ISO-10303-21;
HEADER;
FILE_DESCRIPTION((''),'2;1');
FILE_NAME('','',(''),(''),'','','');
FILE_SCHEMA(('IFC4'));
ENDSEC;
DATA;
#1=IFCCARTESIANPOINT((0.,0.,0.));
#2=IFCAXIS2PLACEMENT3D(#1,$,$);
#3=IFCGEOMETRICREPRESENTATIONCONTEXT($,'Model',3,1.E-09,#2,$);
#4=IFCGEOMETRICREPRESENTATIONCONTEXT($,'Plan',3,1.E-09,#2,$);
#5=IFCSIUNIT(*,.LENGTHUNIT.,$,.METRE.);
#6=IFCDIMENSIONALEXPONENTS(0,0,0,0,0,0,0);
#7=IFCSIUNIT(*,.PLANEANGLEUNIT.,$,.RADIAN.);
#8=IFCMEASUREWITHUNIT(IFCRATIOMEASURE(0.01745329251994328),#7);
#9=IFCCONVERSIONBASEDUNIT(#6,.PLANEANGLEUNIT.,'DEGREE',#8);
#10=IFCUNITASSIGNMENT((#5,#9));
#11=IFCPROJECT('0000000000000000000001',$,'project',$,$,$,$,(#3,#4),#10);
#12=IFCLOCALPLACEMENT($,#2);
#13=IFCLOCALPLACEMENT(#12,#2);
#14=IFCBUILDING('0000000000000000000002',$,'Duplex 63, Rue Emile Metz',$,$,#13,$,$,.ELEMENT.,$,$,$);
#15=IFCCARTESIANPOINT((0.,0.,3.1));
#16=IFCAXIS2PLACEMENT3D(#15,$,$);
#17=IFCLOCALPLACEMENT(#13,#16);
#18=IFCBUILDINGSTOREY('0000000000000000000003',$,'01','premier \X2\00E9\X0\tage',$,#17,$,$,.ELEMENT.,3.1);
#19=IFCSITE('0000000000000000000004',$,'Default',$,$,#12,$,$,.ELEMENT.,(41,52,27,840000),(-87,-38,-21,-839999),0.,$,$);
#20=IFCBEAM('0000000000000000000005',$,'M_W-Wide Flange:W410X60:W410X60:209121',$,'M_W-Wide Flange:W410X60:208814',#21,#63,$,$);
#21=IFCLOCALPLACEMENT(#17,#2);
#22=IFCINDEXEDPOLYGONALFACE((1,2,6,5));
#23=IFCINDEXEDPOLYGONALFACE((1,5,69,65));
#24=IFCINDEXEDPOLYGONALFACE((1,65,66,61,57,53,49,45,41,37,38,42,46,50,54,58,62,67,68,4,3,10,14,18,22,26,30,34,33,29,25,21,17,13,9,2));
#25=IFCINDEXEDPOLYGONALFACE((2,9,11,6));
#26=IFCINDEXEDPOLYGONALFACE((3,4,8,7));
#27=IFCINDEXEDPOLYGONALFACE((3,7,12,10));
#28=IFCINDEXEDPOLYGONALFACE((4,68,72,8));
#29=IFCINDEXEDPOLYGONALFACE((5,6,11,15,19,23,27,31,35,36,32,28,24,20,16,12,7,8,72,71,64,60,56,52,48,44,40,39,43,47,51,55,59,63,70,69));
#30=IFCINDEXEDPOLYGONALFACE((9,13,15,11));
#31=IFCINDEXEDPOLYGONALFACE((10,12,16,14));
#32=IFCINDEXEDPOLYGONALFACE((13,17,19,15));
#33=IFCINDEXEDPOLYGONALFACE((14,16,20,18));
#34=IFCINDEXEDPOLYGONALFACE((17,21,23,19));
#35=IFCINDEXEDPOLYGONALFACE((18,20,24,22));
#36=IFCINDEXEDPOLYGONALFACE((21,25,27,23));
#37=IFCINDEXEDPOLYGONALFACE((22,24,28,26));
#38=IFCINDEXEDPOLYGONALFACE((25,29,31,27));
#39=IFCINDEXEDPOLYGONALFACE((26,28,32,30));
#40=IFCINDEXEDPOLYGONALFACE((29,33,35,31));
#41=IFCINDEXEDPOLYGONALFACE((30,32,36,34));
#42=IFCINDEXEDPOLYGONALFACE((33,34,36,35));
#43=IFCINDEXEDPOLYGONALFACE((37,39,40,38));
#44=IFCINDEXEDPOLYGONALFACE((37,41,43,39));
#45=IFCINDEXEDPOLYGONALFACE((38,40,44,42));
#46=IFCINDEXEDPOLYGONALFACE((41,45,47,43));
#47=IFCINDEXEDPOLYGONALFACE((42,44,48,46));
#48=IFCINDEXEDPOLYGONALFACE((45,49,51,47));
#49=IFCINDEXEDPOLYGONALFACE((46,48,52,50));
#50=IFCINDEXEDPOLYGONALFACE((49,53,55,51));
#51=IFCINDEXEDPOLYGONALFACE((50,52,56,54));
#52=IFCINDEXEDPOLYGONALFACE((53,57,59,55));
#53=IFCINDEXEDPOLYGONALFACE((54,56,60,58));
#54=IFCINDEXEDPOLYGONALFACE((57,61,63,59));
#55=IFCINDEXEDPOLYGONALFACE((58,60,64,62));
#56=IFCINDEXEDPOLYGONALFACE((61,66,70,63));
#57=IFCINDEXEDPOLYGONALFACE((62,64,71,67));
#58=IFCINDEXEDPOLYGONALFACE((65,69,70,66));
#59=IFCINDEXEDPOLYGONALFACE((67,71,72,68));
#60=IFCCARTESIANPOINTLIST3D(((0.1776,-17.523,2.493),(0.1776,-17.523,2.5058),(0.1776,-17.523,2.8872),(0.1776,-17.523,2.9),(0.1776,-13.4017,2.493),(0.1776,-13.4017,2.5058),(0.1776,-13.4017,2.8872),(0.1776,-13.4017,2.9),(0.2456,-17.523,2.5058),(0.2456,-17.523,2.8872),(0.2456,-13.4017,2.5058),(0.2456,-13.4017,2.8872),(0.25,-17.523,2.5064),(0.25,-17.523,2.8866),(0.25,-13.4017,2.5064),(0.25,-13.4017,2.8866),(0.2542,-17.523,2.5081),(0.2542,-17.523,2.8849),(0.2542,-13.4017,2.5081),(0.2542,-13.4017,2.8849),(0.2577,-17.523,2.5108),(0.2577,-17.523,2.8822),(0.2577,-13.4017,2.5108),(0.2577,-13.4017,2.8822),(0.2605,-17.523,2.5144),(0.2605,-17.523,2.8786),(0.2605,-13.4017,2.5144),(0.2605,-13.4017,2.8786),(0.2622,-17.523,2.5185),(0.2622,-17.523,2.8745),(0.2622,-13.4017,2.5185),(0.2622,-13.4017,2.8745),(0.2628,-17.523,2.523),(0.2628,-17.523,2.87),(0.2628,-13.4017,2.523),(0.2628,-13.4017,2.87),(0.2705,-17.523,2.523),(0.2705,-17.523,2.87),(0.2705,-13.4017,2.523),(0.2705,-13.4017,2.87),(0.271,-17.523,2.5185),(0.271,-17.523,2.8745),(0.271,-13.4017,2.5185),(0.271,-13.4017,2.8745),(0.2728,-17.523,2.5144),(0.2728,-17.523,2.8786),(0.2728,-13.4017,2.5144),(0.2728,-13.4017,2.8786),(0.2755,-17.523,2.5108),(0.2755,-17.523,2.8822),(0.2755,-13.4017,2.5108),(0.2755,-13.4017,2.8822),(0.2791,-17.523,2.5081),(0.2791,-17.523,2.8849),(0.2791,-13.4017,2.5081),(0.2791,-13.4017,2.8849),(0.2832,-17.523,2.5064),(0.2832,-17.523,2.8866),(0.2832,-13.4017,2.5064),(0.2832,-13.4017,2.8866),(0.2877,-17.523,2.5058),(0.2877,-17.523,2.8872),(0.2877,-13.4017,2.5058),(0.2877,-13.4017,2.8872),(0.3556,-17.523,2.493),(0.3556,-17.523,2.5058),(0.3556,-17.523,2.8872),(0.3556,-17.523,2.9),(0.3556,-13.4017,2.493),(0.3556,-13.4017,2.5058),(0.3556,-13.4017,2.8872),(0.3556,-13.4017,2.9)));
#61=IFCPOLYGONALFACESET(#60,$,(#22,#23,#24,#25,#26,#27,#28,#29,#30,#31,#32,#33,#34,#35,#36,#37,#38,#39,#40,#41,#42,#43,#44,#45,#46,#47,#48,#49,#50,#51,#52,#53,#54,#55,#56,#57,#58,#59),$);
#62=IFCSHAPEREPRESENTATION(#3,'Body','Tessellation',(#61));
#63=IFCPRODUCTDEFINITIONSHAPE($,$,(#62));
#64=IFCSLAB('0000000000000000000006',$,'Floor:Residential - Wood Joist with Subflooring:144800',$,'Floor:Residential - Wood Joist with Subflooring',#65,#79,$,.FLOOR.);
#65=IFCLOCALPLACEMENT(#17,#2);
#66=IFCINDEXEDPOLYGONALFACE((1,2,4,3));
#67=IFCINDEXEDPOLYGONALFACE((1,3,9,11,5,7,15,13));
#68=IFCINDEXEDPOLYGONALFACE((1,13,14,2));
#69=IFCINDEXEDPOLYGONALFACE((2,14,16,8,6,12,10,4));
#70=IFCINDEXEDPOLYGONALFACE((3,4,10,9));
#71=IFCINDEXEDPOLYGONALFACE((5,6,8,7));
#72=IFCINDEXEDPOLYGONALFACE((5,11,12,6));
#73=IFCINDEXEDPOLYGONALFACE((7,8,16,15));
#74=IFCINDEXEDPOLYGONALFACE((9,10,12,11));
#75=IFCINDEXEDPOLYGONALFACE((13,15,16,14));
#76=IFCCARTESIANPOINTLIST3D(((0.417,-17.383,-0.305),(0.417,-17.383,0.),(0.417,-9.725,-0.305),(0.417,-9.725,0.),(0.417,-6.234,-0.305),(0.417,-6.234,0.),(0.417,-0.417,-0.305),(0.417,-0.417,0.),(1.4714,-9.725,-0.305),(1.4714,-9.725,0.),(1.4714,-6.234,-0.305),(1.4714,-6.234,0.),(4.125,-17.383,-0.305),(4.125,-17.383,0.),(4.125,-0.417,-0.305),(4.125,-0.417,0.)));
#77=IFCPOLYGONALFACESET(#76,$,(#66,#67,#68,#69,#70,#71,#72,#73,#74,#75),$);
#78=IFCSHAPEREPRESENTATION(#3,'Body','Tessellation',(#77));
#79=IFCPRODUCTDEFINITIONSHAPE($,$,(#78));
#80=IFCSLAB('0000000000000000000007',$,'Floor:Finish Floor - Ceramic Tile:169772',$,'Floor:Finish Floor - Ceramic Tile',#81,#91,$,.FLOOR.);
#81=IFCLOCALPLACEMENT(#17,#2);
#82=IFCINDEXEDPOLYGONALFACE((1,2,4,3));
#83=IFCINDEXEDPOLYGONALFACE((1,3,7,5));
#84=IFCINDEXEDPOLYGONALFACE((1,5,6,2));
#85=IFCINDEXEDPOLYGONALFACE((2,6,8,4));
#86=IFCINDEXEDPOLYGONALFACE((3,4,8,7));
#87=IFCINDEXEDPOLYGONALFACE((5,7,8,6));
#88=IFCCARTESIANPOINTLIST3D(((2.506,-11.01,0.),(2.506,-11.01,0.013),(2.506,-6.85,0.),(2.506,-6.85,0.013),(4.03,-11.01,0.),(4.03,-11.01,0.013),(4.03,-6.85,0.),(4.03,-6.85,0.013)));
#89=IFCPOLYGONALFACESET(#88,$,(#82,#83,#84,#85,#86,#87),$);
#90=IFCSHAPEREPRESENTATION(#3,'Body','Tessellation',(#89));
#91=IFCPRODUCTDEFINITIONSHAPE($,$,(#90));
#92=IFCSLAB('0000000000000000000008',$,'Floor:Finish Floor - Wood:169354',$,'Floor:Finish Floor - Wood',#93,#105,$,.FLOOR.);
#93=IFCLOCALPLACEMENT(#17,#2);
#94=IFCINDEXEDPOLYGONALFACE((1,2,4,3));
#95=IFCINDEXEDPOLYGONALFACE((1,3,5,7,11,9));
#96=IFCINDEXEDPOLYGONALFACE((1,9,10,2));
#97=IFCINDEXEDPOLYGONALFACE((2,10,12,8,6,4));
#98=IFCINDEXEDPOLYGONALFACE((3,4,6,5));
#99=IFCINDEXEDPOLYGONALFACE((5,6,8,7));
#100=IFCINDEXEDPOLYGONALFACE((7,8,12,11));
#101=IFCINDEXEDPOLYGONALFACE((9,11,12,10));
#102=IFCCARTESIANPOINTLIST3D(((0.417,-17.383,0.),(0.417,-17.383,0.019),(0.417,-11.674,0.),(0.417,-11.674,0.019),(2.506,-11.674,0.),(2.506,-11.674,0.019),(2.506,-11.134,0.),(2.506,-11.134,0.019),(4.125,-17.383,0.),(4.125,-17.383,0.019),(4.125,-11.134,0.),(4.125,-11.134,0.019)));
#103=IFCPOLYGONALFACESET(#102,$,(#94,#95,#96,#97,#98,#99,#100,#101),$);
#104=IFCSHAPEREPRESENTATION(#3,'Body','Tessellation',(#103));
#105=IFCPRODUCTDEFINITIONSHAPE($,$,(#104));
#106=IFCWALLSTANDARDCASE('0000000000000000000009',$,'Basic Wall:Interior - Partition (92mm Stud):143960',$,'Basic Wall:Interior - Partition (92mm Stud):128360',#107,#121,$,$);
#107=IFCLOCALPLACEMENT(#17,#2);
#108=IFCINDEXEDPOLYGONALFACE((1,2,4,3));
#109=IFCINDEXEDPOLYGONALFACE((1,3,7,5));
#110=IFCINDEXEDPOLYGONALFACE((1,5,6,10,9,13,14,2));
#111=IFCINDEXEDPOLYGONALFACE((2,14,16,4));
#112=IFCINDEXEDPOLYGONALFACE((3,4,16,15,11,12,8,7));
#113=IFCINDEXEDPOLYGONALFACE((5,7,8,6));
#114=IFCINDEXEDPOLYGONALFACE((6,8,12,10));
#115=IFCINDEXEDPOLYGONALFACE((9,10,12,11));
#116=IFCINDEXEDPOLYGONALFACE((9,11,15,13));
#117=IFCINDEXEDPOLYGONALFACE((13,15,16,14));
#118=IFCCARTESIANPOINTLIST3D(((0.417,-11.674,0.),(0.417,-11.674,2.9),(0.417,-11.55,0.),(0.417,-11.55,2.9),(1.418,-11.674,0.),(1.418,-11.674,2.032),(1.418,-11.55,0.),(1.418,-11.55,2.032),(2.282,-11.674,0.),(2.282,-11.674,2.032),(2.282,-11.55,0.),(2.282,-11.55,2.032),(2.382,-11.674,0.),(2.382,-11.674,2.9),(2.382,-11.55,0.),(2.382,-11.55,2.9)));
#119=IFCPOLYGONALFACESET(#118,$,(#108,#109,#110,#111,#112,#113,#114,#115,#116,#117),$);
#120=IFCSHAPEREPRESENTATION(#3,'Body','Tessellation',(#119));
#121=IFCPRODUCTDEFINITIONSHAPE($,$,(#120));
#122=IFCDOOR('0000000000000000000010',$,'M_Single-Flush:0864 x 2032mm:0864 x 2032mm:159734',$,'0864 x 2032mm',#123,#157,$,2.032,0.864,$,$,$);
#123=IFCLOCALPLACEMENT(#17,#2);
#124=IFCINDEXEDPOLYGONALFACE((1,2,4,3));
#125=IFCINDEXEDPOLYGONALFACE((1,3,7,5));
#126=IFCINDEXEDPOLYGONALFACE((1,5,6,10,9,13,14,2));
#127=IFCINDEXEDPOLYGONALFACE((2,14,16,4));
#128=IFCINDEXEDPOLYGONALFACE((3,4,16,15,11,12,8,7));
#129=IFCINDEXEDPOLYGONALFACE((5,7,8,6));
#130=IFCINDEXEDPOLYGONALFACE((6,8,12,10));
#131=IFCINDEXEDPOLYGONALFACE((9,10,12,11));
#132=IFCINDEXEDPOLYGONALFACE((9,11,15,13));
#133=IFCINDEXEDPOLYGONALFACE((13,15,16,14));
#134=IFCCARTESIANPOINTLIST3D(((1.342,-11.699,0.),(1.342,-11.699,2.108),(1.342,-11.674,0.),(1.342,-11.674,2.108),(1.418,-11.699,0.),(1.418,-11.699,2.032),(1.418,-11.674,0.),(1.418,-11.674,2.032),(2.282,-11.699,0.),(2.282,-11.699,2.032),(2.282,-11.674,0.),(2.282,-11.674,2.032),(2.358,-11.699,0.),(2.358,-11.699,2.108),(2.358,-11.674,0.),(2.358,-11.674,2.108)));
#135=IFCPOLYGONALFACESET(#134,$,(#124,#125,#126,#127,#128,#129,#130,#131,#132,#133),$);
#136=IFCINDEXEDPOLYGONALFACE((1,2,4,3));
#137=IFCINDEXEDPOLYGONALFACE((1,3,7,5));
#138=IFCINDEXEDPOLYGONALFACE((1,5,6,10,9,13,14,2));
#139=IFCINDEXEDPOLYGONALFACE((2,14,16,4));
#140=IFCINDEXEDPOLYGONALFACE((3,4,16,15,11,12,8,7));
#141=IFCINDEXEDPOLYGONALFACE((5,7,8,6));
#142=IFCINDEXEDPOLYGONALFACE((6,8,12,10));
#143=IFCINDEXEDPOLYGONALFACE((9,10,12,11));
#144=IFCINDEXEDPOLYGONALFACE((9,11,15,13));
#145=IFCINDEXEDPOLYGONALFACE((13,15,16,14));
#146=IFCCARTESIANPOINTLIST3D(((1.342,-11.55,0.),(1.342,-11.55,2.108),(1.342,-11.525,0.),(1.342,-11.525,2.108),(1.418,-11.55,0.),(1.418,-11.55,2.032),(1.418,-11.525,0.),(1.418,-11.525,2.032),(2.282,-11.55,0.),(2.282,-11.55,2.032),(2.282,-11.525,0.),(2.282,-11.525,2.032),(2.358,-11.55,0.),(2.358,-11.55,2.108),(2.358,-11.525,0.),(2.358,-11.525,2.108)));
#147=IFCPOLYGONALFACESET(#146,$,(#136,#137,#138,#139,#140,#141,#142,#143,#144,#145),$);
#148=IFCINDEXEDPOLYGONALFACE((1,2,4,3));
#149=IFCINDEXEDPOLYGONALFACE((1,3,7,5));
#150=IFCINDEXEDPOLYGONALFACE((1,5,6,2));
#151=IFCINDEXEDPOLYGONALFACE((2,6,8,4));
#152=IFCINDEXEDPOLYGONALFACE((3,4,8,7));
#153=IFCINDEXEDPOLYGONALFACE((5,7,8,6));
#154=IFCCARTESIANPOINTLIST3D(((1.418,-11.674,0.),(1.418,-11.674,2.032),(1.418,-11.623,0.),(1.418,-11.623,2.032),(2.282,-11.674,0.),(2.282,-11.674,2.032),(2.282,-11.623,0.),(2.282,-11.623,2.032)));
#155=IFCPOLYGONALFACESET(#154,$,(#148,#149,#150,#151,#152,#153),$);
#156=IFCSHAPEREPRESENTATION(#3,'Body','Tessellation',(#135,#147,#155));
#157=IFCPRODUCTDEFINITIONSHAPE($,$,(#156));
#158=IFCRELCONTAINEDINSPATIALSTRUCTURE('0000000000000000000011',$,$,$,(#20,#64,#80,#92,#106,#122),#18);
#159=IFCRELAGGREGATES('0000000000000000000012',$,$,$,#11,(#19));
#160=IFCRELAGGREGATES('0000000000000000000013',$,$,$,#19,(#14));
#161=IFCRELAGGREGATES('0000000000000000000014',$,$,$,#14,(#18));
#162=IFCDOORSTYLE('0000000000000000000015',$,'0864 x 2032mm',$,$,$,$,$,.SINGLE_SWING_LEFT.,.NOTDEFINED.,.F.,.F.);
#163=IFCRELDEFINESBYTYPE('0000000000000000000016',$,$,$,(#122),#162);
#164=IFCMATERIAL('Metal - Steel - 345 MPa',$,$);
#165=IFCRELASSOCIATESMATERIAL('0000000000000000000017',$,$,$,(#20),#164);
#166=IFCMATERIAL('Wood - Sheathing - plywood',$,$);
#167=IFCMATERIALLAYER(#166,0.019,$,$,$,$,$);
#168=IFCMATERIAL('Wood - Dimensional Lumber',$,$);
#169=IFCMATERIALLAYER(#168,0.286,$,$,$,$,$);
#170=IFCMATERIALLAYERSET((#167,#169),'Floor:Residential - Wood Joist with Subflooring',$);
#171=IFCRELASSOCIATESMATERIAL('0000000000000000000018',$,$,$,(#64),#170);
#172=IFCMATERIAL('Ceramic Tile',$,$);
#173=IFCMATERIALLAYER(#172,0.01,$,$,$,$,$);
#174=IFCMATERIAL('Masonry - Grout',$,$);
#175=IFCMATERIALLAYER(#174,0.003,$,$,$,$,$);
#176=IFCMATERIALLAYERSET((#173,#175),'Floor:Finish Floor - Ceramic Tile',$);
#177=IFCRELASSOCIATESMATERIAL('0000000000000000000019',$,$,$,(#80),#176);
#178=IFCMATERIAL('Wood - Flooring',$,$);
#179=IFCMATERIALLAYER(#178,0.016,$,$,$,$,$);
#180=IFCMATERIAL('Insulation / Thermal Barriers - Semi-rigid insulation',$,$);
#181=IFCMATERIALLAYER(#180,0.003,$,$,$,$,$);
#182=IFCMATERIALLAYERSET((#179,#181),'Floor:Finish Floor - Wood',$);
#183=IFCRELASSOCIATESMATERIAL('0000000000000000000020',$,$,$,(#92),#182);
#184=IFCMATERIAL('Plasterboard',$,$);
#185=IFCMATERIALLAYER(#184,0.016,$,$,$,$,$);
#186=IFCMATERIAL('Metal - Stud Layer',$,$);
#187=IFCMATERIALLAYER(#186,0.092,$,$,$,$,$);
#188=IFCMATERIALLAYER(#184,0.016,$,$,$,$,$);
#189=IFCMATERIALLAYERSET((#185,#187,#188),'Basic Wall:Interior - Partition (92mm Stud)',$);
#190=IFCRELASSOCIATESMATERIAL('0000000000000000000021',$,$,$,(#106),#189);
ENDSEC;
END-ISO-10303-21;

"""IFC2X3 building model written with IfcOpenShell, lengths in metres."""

from ifc_helpers import new_model, entity, si_unit, converted_unit, frame, frame_2d, origin, origin_2d_with_axis, place, context, project, spatial, polyline, circle_curve, parameter, trimmed, segment, composite_curve, rectangle, outline, extrude, source, transform, mapped, material, layer, layer_set, layer_usage, type_object, type_shapes, element, fill, save


model = new_model("IFC2X3")

# Units and contexts
model_context = context("Model", 3, precision=1e-09, world=origin())
plan_context = context("Plan", 3, precision=1e-09, world=origin())
ifc_project = project(units=[si_unit("LENGTHUNIT", "METRE"), converted_unit("PLANEANGLEUNIT", "DEGREE", entity("IfcRatioMeasure", 0.01745329251994328), si_unit("PLANEANGLEUNIT", "RADIAN"), dimensions=[0, 0, 0, 0, 0, 0, 0])], contexts=[model_context, plan_context])

# Site, building, storey
site_placement = place(None, origin())
site = spatial("IfcSite", under=ifc_project, at=site_placement, Name="Default", CompositionType="ELEMENT", RefLatitude=(41, 52, 27, 840000), RefLongitude=(-87, -38, -21, -839999), RefElevation=0.0)
building_placement = place(site_placement, origin())
building = spatial("IfcBuilding", under=site, at=building_placement, Name="Duplex 63, Rue Emile Metz", CompositionType="ELEMENT")
storey_placement = place(building_placement, frame((0.0, 0.0, 3.1)))
storey = spatial("IfcBuildingStorey", under=building, at=storey_placement, Name="01", Description="premier étage", CompositionType="ELEMENT", Elevation=3.1)

# Beam
ifc_material_1 = material(Name="Metal - Steel - 345 MPa")
beam_placement = place(storey_placement, frame((0.2666, -13.4017, 2.9), z_axis=(0.0, 0.0, 1.0), x_axis=(-1.0, 0.0, 0.0)))
element("IfcBeam", 1, at=beam_placement, inside=storey, material=ifc_material_1, Name="M_W-Wide Flange:W410X60:W410X60:209121", ObjectType="M_W-Wide Flange:W410X60:208814", context=model_context, shape_type="SweptSolid", body=[
    extrude(outline(composite_curve([segment(polyline([(0.1907, -0.089), (0.2035, -0.089)]), True, "CONTINUOUS"), segment(polyline([(0.2035, -0.089), (0.2035, 0.089)]), True, "CONTINUOUS"), segment(polyline([(0.2035, 0.089), (0.1907, 0.089)]), True, "CONTINUOUS"), segment(polyline([(0.1907, 0.089), (0.1907, 0.021)]), True, "CONTINUOUS"), segment(trimmed(circle_curve(frame_2d((0.1735, 0.021), x_axis=(1.0, 0.0)), 0.0172), [parameter(270.0)], [parameter(360.0)], True, "PARAMETER"), False, "CONTINUOUS"), segment(polyline([(0.1735, 0.0038), (-0.1735, 0.0038)]), True, "CONTINUOUS"), segment(trimmed(circle_curve(frame_2d((-0.1735, 0.021), x_axis=(0.0, -1.0)), 0.0172), [parameter(270.0)], [parameter(360.0)], True, "PARAMETER"), False, "CONTINUOUS"), segment(polyline([(-0.1907, 0.021), (-0.1907, 0.089)]), True, "CONTINUOUS"), segment(polyline([(-0.1907, 0.089), (-0.2035, 0.089)]), True, "CONTINUOUS"), segment(polyline([(-0.2035, 0.089), (-0.2035, -0.089)]), True, "CONTINUOUS"), segment(polyline([(-0.2035, -0.089), (-0.1907, -0.089)]), True, "CONTINUOUS"), segment(polyline([(-0.1907, -0.089), (-0.1907, -0.0211)]), True, "CONTINUOUS"), segment(trimmed(circle_curve(frame_2d((-0.1735, -0.0211), x_axis=(-1.0, 0.0)), 0.0172), [parameter(270.0)], [parameter(0.0)], True, "PARAMETER"), False, "CONTINUOUS"), segment(polyline([(-0.1735, -0.0039), (0.1735, -0.0039)]), True, "CONTINUOUS"), segment(trimmed(circle_curve(frame_2d((0.1735, -0.0211), x_axis=(0.0, 1.0)), 0.0172), [parameter(270.0)], [parameter(0.0)], True, "PARAMETER"), False, "CONTINUOUS"), segment(polyline([(0.1907, -0.0211), (0.1907, -0.089)]), True, "CONTINUOUS")], self_intersect=False)), frame((0.0, 4.1213, -0.2035), z_axis=(0.0, -1.0, 0.0), x_axis=(0.0, 0.0, -1.0)), (0.0, 0.0, 1.0), 4.1213),
])

# Slabs
ifc_material_2 = material(Name="Wood - Sheathing - plywood")
ifc_layer_1 = layer(ifc_material_2, 0.019)
ifc_material_3 = material(Name="Wood - Dimensional Lumber")
ifc_layer_2 = layer(ifc_material_3, 0.286)
ifc_layer_set_1 = layer_set([ifc_layer_1, ifc_layer_2], Name="Floor:Residential - Wood Joist with Subflooring")
ifc_layer_usage_1 = layer_usage(ifc_layer_set_1, "AXIS3", "POSITIVE", 0.0)
slab_1_placement = place(storey_placement, frame((0.417, -17.383, -0.305)))
element("IfcSlab", 2, at=slab_1_placement, inside=storey, material=ifc_layer_usage_1, Name="Floor:Residential - Wood Joist with Subflooring:144800", ObjectType="Floor:Residential - Wood Joist with Subflooring", PredefinedType="FLOOR", context=model_context, shape_type="SweptSolid", body=[
    extrude(outline(polyline([(-1.854, 8.483), (-1.854, -8.483), (1.854, -8.483), (1.854, -0.825), (0.7996, -0.825), (0.7996, 2.666), (1.854, 2.666), (1.854, 8.483), (-1.854, 8.483)])), frame((1.854, 8.483, 0.305), z_axis=(0.0, 0.0, -1.0), x_axis=(-1.0, 0.0, 0.0)), (0.0, 0.0, 1.0), 0.305),
])
ifc_material_4 = material(Name="Ceramic Tile")
ifc_layer_3 = layer(ifc_material_4, 0.01)
ifc_material_5 = material(Name="Masonry - Grout")
ifc_layer_4 = layer(ifc_material_5, 0.003)
ifc_layer_set_2 = layer_set([ifc_layer_3, ifc_layer_4], Name="Floor:Finish Floor - Ceramic Tile")
ifc_layer_usage_2 = layer_usage(ifc_layer_set_2, "AXIS3", "POSITIVE", 0.0)
slab_2_placement = place(storey_placement, frame((2.506, -11.01, 0.0)))
element("IfcSlab", 3, at=slab_2_placement, inside=storey, material=ifc_layer_usage_2, Name="Floor:Finish Floor - Ceramic Tile:169772", ObjectType="Floor:Finish Floor - Ceramic Tile", PredefinedType="FLOOR", context=model_context, shape_type="SweptSolid", body=[
    extrude(rectangle(XDim=4.16, YDim=1.524, at=frame_2d((0.0, 0.0), x_axis=(0.0, -1.0))), frame((0.762, 2.08, 0.013), z_axis=(0.0, 0.0, -1.0), x_axis=(-1.0, 0.0, 0.0)), (0.0, 0.0, 1.0), 0.013),
])
ifc_material_6 = material(Name="Wood - Flooring")
ifc_layer_5 = layer(ifc_material_6, 0.016)
ifc_material_7 = material(Name="Insulation / Thermal Barriers - Semi-rigid insulation")
ifc_layer_6 = layer(ifc_material_7, 0.003)
ifc_layer_set_3 = layer_set([ifc_layer_5, ifc_layer_6], Name="Floor:Finish Floor - Wood")
ifc_layer_usage_3 = layer_usage(ifc_layer_set_3, "AXIS3", "POSITIVE", 0.0)
slab_3_placement = place(storey_placement, frame((0.417, -17.383, 0.0)))
element("IfcSlab", 4, at=slab_3_placement, inside=storey, material=ifc_layer_usage_3, Name="Floor:Finish Floor - Wood:169354", ObjectType="Floor:Finish Floor - Wood", PredefinedType="FLOOR", context=model_context, shape_type="SweptSolid", body=[
    extrude(outline(polyline([(-1.854, -3.1245), (1.854, -3.1245), (1.854, 2.5845), (-0.235, 2.5845), (-0.235, 3.1245), (-1.854, 3.1245), (-1.854, -3.1245)])), frame((1.854, 3.1245, 0.019), z_axis=(0.0, 0.0, -1.0), x_axis=(-1.0, 0.0, 0.0)), (0.0, 0.0, 1.0), 0.019),
])

# Shared definitions
ifc_material_8 = material(Name="Metal - Stud Layer")
ifc_material_9 = material(Name="Plasterboard")

# Wall, opening, door
ifc_layer_7 = layer(ifc_material_9, 0.016)
ifc_layer_8 = layer(ifc_material_8, 0.092)
ifc_layer_9 = layer(ifc_material_9, 0.016)
ifc_layer_set_4 = layer_set([ifc_layer_7, ifc_layer_8, ifc_layer_9], Name="Basic Wall:Interior - Partition (92mm Stud)")
ifc_layer_usage_4 = layer_usage(ifc_layer_set_4, "AXIS2", "NEGATIVE", 0.062)
wall_1_placement = place(storey_placement, frame((2.382, -11.612, 0.0), z_axis=(0.0, 0.0, 1.0), x_axis=(-1.0, 0.0, 0.0)))
wall_1 = element("IfcWallStandardCase", 5, at=wall_1_placement, inside=storey, material=ifc_layer_usage_4, Name="Basic Wall:Interior - Partition (92mm Stud):143960", ObjectType="Basic Wall:Interior - Partition (92mm Stud):128360", context=model_context, shape_type="SweptSolid", body=[
    extrude(rectangle(XDim=1.965, YDim=0.124, at=frame_2d((0.9825, 0.0), x_axis=(-1.0, 0.0))), origin(), (0.0, 0.0, 1.0), 2.9),
])
opening_1_placement = place(wall_1_placement, frame((0.1, -0.062, 0.0)))
opening_1 = element("IfcOpeningElement", 6, at=opening_1_placement, cuts=wall_1, ObjectType="Opening", context=model_context, shape_type="SweptSolid", body=[
    extrude(rectangle(XDim=0.864, YDim=2.032, at=frame_2d((1.016, 0.432), x_axis=(0.0, -1.0))), frame((0.0, 0.0, 0.0), z_axis=(0.0, 1.0, 0.0), x_axis=(0.0, 0.0, 1.0)), (0.0, 0.0, 1.0), 0.124),
])
door_style = type_object("IfcDoorStyle", Name="0864 x 2032mm", ConstructionType="NOTDEFINED", OperationType="SINGLE_SWING_LEFT", ParameterTakesPrecedence=False, Sizeable=False)
shared_shape_1 = source(origin(), model_context, "Body", "SweptSolid", [
    extrude(outline(polyline([(-0.508, -1.073), (0.508, -1.073), (0.508, 1.035), (0.432, 1.035), (0.432, -0.997), (-0.432, -0.997), (-0.432, 1.035), (-0.508, 1.035), (-0.508, -1.073)])), frame((0.432, 0.149, 1.035), z_axis=(0.0, -1.0, 0.0), x_axis=(-1.0, 0.0, 0.0)), (0.0, 0.0, 1.0), 0.025),
    extrude(outline(polyline([(-1.073, -0.508), (1.035, -0.508), (1.035, -0.432), (-0.997, -0.432), (-0.997, 0.432), (1.035, 0.432), (1.035, 0.508), (-1.073, 0.508), (-1.073, -0.508)])), frame((0.432, 0.0, 1.035), z_axis=(0.0, -1.0, 0.0), x_axis=(0.0, 0.0, -1.0)), (0.0, 0.0, 1.0), 0.025),
    extrude(rectangle(XDim=0.864, YDim=0.051, at=origin_2d_with_axis()), frame((0.432, 0.0985, 0.0)), (0.0, 0.0, 1.0), 2.032),
])
type_shapes(door_style, [shared_shape_1])
door_placement = place(opening_1_placement, origin())
door = element("IfcDoor", 7, at=door_placement, inside=storey, type_object=door_style, Name="M_Single-Flush:0864 x 2032mm:0864 x 2032mm:159734", ObjectType="0864 x 2032mm", OverallHeight=2.032, OverallWidth=0.864, context=model_context, shape_type="MappedRepresentation", body=[
    mapped(shared_shape_1, transform((0.0, 0.0, 0.0), scale=1.0)),
])
fill(opening_1, door)

save(model, "model.ifc")
